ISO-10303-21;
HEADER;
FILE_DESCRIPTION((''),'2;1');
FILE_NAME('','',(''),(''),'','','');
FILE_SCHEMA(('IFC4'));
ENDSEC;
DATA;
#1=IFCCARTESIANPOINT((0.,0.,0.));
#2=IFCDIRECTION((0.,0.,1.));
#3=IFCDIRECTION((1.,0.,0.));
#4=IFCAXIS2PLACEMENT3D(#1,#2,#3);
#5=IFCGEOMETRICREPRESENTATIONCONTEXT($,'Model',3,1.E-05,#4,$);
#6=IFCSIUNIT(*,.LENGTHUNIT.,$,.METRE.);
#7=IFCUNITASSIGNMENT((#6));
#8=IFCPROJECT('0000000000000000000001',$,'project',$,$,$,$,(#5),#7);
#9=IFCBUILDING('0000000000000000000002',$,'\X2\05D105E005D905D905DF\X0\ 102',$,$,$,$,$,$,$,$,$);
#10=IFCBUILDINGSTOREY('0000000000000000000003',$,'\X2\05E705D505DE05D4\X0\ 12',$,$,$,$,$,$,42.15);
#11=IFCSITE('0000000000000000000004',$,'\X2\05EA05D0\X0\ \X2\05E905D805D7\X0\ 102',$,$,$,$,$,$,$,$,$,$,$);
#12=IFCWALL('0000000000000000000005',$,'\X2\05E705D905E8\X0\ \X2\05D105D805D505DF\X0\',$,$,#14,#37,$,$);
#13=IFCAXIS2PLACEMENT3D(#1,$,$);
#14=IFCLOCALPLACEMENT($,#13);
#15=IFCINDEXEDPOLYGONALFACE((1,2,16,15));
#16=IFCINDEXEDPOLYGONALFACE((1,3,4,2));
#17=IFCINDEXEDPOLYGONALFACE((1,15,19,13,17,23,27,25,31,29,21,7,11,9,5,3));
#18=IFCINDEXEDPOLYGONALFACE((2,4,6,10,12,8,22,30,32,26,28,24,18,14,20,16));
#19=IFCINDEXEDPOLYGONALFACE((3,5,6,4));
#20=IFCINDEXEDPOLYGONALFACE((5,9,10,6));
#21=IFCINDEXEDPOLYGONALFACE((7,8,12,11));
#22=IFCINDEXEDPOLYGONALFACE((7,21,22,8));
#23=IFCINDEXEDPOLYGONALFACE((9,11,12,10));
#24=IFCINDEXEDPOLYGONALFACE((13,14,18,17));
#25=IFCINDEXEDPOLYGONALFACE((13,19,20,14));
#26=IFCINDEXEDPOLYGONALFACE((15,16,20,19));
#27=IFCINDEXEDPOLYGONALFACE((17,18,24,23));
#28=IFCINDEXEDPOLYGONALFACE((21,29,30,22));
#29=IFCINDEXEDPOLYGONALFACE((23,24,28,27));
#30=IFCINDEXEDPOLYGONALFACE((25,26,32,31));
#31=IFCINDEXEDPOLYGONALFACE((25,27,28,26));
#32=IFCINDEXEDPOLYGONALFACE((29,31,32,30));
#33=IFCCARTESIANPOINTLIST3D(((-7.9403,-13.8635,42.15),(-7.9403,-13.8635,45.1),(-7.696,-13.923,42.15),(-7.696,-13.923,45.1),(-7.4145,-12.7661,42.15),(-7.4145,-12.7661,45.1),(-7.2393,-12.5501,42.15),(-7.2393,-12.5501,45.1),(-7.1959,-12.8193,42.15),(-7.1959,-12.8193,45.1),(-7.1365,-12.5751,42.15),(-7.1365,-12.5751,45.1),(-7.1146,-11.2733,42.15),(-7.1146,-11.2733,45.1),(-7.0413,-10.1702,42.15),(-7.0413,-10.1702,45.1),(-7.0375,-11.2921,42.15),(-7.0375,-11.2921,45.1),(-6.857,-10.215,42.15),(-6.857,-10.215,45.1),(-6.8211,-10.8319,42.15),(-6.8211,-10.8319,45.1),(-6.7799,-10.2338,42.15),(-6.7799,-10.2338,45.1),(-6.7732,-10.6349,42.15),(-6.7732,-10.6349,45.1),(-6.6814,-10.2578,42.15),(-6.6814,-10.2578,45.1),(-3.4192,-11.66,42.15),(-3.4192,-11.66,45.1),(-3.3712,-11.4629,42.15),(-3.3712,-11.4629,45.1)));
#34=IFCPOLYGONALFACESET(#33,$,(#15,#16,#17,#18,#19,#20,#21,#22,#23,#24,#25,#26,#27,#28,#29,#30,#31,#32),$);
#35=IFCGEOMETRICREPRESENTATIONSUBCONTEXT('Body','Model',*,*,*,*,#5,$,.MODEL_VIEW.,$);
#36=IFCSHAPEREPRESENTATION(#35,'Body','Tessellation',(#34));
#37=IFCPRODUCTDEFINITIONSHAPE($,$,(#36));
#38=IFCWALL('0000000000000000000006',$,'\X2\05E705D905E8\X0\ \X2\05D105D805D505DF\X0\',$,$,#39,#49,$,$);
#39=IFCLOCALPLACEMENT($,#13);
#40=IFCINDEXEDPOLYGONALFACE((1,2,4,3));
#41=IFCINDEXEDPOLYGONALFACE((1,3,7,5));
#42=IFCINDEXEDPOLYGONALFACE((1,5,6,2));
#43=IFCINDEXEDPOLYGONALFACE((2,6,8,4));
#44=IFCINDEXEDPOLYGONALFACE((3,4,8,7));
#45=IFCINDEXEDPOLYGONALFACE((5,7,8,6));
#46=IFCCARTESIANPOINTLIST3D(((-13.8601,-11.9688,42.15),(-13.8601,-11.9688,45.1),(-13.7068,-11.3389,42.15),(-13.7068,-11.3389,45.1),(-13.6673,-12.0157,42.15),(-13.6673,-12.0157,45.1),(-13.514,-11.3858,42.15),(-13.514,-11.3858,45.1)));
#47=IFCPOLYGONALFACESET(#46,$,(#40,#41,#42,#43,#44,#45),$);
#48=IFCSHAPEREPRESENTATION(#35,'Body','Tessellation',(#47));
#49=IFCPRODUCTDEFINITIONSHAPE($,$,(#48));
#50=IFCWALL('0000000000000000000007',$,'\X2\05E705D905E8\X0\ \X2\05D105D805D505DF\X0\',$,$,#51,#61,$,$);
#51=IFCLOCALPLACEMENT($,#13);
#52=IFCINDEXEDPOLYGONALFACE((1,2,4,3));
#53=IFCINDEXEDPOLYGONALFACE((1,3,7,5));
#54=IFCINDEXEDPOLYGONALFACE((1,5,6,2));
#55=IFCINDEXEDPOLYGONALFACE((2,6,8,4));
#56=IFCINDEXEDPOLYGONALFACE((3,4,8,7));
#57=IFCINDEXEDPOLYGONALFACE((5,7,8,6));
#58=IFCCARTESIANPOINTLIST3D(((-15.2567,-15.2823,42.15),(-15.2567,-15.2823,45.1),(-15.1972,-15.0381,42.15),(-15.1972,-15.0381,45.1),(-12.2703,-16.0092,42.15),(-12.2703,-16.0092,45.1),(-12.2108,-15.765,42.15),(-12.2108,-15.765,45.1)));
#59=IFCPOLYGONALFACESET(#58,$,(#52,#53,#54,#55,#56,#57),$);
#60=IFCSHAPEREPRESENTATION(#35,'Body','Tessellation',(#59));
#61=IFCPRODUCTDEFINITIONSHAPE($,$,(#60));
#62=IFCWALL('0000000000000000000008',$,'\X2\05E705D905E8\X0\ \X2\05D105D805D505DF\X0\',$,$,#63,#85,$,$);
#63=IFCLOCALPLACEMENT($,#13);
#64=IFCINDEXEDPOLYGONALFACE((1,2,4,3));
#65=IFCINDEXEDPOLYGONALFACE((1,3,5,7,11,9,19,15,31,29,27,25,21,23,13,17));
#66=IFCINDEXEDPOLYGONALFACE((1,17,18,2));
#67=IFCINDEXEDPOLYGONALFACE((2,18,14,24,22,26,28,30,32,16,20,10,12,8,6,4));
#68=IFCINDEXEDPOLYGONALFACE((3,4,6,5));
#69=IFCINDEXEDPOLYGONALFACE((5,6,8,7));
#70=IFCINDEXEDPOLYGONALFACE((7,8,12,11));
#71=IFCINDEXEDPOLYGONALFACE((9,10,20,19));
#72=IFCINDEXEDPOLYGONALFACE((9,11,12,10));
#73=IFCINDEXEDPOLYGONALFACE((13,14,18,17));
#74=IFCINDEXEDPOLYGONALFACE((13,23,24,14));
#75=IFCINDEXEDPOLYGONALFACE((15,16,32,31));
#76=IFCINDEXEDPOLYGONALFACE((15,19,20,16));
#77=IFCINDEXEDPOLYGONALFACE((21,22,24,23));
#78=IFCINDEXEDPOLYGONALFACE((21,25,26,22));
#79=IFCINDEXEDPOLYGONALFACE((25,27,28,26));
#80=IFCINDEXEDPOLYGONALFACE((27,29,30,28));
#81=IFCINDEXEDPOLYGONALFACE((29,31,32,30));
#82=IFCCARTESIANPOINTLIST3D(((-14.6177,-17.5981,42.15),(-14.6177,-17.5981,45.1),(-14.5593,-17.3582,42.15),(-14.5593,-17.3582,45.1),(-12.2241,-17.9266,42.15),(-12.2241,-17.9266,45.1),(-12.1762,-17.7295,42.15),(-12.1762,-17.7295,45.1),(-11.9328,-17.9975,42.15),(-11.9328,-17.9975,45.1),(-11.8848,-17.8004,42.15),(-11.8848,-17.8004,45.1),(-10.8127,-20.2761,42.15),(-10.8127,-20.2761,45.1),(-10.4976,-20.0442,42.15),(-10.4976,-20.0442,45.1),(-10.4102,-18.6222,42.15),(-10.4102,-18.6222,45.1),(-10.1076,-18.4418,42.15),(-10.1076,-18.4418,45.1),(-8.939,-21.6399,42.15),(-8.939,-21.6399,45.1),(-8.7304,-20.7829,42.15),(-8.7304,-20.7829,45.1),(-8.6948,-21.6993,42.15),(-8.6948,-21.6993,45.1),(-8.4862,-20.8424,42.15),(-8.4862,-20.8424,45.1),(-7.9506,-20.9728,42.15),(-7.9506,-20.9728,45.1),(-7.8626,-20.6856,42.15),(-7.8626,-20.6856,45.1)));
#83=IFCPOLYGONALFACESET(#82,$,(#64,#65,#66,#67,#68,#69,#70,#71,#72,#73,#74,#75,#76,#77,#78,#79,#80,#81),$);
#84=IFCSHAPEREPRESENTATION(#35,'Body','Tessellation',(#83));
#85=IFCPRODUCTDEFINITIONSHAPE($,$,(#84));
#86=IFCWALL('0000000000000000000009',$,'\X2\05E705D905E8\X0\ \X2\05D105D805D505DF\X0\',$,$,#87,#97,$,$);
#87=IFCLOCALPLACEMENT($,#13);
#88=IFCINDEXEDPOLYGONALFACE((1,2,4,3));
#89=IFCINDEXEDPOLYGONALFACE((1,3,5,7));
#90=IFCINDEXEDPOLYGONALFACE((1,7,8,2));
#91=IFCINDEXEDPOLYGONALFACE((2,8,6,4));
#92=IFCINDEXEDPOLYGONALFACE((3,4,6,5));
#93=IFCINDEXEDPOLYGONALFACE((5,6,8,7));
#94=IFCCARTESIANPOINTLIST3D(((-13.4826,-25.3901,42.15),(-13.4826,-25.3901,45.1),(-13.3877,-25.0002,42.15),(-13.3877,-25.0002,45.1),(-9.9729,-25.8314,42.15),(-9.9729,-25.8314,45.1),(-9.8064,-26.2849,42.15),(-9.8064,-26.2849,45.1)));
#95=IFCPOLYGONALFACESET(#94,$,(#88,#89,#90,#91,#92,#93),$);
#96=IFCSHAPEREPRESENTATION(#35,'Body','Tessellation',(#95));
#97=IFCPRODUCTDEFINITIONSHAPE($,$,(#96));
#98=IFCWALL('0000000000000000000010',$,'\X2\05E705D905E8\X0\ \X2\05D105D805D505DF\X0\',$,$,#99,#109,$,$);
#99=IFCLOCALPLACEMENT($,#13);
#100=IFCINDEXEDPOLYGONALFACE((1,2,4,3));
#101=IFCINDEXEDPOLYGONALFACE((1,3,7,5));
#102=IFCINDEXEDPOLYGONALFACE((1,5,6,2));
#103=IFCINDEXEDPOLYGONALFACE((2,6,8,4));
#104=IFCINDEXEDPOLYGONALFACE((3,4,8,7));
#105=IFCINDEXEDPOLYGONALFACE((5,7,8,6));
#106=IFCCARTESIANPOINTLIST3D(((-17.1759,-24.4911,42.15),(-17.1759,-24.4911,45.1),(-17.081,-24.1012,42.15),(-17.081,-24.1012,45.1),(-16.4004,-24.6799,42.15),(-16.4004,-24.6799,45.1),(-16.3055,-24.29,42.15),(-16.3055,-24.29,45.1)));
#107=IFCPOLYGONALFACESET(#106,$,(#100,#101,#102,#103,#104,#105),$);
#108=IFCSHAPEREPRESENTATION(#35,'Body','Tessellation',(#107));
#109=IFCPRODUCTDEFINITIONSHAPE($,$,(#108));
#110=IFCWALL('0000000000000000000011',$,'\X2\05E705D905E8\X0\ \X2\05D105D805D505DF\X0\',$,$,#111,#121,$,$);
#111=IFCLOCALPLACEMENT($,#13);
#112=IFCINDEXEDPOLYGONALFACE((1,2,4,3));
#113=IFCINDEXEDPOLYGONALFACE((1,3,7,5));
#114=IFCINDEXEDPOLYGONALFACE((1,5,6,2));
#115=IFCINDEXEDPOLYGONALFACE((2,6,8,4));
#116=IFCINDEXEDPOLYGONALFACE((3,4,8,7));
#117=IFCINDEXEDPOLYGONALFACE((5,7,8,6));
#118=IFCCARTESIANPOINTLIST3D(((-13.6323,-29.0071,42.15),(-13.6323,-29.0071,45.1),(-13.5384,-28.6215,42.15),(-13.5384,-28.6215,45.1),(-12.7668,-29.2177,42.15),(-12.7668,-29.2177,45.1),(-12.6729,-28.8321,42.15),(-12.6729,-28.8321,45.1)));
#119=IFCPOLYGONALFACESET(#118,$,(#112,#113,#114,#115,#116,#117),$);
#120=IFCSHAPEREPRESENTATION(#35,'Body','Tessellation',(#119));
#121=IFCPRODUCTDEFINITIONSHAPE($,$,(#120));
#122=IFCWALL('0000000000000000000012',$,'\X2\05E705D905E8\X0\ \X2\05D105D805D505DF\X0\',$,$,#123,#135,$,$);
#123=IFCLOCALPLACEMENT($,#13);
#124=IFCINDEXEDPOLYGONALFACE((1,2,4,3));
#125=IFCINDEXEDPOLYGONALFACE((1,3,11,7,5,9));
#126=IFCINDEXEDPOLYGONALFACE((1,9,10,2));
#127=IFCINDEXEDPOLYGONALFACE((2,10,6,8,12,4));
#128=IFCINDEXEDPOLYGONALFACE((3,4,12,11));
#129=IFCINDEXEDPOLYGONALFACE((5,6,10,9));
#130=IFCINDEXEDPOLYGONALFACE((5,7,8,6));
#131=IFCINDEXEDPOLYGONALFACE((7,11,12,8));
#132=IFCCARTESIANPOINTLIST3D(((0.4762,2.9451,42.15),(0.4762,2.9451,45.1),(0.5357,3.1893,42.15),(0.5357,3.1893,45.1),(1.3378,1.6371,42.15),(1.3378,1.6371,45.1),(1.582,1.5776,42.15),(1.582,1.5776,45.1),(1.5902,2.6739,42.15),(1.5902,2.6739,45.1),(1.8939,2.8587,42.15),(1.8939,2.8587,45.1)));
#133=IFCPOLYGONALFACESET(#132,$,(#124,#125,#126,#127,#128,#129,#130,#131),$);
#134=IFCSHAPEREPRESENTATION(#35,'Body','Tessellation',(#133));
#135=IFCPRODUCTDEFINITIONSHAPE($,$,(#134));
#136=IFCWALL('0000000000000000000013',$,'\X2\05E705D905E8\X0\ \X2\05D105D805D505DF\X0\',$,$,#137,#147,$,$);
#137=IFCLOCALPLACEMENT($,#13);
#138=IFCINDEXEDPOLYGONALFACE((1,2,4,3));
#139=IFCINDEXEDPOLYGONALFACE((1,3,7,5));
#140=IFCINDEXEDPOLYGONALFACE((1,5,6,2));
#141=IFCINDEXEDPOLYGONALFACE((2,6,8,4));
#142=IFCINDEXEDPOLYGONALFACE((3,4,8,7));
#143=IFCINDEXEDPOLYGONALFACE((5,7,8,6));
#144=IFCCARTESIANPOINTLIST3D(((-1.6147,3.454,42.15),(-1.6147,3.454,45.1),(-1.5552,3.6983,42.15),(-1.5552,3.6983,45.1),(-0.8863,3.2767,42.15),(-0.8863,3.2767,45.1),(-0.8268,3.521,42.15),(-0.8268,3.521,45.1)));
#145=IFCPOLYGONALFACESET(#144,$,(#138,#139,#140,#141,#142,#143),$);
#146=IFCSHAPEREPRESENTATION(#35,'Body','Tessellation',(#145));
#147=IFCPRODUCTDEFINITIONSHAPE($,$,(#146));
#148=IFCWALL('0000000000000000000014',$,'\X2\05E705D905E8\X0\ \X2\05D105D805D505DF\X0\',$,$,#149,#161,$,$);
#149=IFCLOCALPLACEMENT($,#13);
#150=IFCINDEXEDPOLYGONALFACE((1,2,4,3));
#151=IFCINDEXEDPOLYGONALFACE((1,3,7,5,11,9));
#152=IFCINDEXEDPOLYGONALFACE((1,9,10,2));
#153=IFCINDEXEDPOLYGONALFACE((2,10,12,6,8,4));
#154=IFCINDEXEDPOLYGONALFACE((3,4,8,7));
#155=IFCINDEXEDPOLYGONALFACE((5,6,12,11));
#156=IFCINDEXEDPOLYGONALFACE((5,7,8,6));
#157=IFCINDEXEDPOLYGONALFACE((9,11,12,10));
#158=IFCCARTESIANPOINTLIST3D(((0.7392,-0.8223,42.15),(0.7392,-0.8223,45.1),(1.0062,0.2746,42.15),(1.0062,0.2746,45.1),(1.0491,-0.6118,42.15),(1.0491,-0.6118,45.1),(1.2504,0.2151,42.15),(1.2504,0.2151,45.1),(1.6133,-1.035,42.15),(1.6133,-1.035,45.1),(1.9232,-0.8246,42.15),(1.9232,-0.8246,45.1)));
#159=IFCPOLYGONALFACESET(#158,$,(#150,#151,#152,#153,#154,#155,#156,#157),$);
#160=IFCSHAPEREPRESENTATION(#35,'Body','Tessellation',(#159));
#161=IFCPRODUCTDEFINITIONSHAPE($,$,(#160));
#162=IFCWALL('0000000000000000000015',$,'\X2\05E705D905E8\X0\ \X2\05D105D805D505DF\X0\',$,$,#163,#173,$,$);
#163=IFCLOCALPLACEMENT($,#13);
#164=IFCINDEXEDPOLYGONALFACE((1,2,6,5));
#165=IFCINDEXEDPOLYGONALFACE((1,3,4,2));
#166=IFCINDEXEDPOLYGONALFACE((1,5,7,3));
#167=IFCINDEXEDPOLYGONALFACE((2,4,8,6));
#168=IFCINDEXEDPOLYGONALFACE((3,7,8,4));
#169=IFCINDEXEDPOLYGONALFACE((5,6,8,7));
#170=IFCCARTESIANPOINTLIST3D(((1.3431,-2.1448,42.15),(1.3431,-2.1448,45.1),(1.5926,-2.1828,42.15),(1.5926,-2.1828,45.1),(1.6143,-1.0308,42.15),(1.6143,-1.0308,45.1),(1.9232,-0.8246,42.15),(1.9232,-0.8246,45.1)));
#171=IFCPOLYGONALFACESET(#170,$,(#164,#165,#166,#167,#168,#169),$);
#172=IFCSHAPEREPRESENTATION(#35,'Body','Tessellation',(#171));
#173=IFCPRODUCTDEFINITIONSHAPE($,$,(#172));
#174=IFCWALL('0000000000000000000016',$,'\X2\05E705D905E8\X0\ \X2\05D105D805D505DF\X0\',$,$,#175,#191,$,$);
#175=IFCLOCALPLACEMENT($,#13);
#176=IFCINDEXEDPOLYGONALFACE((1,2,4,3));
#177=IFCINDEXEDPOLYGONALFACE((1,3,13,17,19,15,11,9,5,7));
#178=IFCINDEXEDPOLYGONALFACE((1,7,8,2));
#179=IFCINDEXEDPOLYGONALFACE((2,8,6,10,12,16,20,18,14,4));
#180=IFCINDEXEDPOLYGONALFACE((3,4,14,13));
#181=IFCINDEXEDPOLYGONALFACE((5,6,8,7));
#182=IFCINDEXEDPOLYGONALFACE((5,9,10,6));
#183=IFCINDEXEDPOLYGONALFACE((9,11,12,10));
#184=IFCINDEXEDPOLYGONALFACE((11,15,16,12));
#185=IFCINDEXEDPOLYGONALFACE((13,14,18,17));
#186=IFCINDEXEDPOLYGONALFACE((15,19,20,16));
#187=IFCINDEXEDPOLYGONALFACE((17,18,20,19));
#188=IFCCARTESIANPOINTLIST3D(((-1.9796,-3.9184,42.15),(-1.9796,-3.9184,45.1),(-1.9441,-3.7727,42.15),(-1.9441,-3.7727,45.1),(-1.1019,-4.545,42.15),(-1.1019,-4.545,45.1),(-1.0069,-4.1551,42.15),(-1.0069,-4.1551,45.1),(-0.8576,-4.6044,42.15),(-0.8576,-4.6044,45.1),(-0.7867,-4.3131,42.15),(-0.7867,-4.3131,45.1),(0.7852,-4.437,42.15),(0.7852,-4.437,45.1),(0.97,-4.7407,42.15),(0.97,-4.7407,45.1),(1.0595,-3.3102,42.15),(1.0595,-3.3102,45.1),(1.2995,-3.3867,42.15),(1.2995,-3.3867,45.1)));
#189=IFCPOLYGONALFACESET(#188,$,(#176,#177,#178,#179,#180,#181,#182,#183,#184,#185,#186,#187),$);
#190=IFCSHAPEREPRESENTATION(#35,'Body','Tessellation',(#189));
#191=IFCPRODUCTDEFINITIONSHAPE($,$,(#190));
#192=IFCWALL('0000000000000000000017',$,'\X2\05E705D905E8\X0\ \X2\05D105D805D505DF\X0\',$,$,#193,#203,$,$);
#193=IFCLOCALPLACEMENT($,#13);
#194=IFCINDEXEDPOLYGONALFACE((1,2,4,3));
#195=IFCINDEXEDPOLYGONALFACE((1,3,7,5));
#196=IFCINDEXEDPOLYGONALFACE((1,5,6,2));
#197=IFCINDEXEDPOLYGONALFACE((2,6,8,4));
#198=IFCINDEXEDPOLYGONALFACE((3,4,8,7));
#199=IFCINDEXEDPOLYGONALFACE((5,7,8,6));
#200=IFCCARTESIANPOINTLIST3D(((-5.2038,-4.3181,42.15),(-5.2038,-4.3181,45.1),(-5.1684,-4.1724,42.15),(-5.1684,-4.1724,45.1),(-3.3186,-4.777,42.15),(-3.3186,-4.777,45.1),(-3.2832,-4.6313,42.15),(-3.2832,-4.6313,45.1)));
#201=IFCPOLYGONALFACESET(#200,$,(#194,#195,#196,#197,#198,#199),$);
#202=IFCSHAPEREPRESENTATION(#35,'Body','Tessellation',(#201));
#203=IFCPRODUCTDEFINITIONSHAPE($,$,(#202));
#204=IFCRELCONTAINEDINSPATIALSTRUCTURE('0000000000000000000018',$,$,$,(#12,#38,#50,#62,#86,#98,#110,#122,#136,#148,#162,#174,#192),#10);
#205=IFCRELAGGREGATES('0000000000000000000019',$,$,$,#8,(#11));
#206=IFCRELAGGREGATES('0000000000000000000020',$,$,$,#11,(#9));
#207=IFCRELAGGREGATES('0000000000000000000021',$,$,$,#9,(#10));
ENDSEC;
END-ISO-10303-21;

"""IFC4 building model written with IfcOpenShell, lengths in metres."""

from ifc_helpers import new_model, si_unit, frame, origin_with_axes, context, subcontext, project, spatial, polyline, outline, extrude, element, save


model = new_model("IFC4")

# Units and contexts
model_context = context("Model", 3, precision=1e-05, world=origin_with_axes())
body_context = subcontext(model_context, "Body", "Model", "MODEL_VIEW")
ifc_project = project(units=[si_unit("LENGTHUNIT", "METRE")], contexts=[model_context])

# Site, building, storey
site = spatial("IfcSite", under=ifc_project, Name="תא שטח 102")
building = spatial("IfcBuilding", under=site, Name="בניין 102")
storey = spatial("IfcBuildingStorey", under=building, Name="קומה 12", Elevation=42.15)

# Walls
element("IfcWall", 1, inside=storey, Name="קיר בטון", context=body_context, shape_type="SweptSolid", body=[
    extrude(outline(polyline([(-7.0413, -10.1702), (-7.9403, -13.8635), (-7.696, -13.923), (-7.4145, -12.7661), (-7.1959, -12.8193), (-7.1365, -12.5751), (-7.2393, -12.5501), (-6.8211, -10.8319), (-3.4192, -11.66), (-3.3712, -11.4629), (-6.7732, -10.6349), (-6.6814, -10.2578), (-6.7799, -10.2338), (-7.0375, -11.2921), (-7.1146, -11.2733), (-6.857, -10.215), (-7.0413, -10.1702)])), frame((0.0, 0.0, 42.15)), (0.0, 0.0, 1.0), 2.95),
])
element("IfcWall", 2, inside=storey, Name="קיר בטון", context=body_context, shape_type="SweptSolid", body=[
    extrude(outline(polyline([(-13.6673, -12.0157), (-13.514, -11.3858), (-13.7068, -11.3389), (-13.8601, -11.9688), (-13.6673, -12.0157)])), frame((0.0, 0.0, 42.15)), (0.0, 0.0, 1.0), 2.95),
])
element("IfcWall", 3, inside=storey, Name="קיר בטון", context=body_context, shape_type="SweptSolid", body=[
    extrude(outline(polyline([(-15.1972, -15.0381), (-15.2567, -15.2823), (-12.2703, -16.0092), (-12.2108, -15.765), (-15.1972, -15.0381)])), frame((0.0, 0.0, 42.15)), (0.0, 0.0, 1.0), 2.95),
])
element("IfcWall", 4, inside=storey, Name="קיר בטון", context=body_context, shape_type="SweptSolid", body=[
    extrude(outline(polyline([(-12.2241, -17.9266), (-14.5593, -17.3582), (-14.6177, -17.5981), (-10.4102, -18.6222), (-10.8127, -20.2761), (-8.7304, -20.7829), (-8.939, -21.6399), (-8.6948, -21.6993), (-8.4862, -20.8424), (-7.9506, -20.9728), (-7.8626, -20.6856), (-10.4976, -20.0442), (-10.1076, -18.4418), (-11.9328, -17.9975), (-11.8848, -17.8004), (-12.1762, -17.7295), (-12.2241, -17.9266)])), frame((0.0, 0.0, 42.15)), (0.0, 0.0, 1.0), 2.95),
])
element("IfcWall", 5, inside=storey, Name="קיר בטון", context=body_context, shape_type="SweptSolid", body=[
    extrude(outline(polyline([(-9.9729, -25.8314), (-13.3877, -25.0002), (-13.4826, -25.3901), (-9.8064, -26.2849), (-9.9729, -25.8314)])), frame((0.0, 0.0, 42.15)), (0.0, 0.0, 1.0), 2.95),
])
element("IfcWall", 6, inside=storey, Name="קיר בטון", context=body_context, shape_type="SweptSolid", body=[
    extrude(outline(polyline([(-16.4004, -24.6799), (-16.3055, -24.29), (-17.081, -24.1012), (-17.1759, -24.4911), (-16.4004, -24.6799)])), frame((0.0, 0.0, 42.15)), (0.0, 0.0, 1.0), 2.95),
])
element("IfcWall", 7, inside=storey, Name="קיר בטון", context=body_context, shape_type="SweptSolid", body=[
    extrude(outline(polyline([(-12.7668, -29.2177), (-12.6729, -28.8321), (-13.5384, -28.6215), (-13.6323, -29.0071), (-12.7668, -29.2177)])), frame((0.0, 0.0, 42.15)), (0.0, 0.0, 1.0), 2.95),
])
element("IfcWall", 8, inside=storey, Name="קיר בטון", context=body_context, shape_type="SweptSolid", body=[
    extrude(outline(polyline([(1.3378, 1.6371), (1.582, 1.5776), (1.8939, 2.8587), (0.5357, 3.1893), (0.4762, 2.9451), (1.5902, 2.6739), (1.3378, 1.6371)])), frame((0.0, 0.0, 42.15)), (0.0, 0.0, 1.0), 2.95),
])
element("IfcWall", 9, inside=storey, Name="קיר בטון", context=body_context, shape_type="SweptSolid", body=[
    extrude(outline(polyline([(-1.5552, 3.6983), (-1.6147, 3.454), (-0.8863, 3.2767), (-0.8268, 3.521), (-1.5552, 3.6983)])), frame((0.0, 0.0, 42.15)), (0.0, 0.0, 1.0), 2.95),
])
element("IfcWall", 10, inside=storey, Name="קיר בטון", context=body_context, shape_type="SweptSolid", body=[
    extrude(outline(polyline([(1.9232, -0.8246), (1.0491, -0.6118), (1.2504, 0.2151), (1.0062, 0.2746), (0.7392, -0.8223), (1.6133, -1.035), (1.9232, -0.8246)])), frame((0.0, 0.0, 42.15)), (0.0, 0.0, 1.0), 2.95),
])
element("IfcWall", 11, inside=storey, Name="קיר בטון", context=body_context, shape_type="SweptSolid", body=[
    extrude(outline(polyline([(1.3431, -2.1448), (1.5926, -2.1828), (1.9232, -0.8246), (1.6143, -1.0308), (1.3431, -2.1448)])), frame((0.0, 0.0, 42.15)), (0.0, 0.0, 1.0), 2.95),
])
element("IfcWall", 12, inside=storey, Name="קיר בטון", context=body_context, shape_type="SweptSolid", body=[
    extrude(outline(polyline([(-1.9441, -3.7727), (-1.9796, -3.9184), (-1.0069, -4.1551), (-1.1019, -4.545), (-0.8576, -4.6044), (-0.7867, -4.3131), (0.97, -4.7407), (1.2995, -3.3867), (1.0595, -3.3102), (0.7852, -4.437), (-1.9441, -3.7727)])), frame((0.0, 0.0, 42.15)), (0.0, 0.0, 1.0), 2.95),
])
element("IfcWall", 13, inside=storey, Name="קיר בטון", context=body_context, shape_type="SweptSolid", body=[
    extrude(outline(polyline([(-3.2832, -4.6313), (-5.1684, -4.1724), (-5.2038, -4.3181), (-3.3186, -4.777), (-3.2832, -4.6313)])), frame((0.0, 0.0, 42.15)), (0.0, 0.0, 1.0), 2.95),
])

save(model, "model.ifc")
